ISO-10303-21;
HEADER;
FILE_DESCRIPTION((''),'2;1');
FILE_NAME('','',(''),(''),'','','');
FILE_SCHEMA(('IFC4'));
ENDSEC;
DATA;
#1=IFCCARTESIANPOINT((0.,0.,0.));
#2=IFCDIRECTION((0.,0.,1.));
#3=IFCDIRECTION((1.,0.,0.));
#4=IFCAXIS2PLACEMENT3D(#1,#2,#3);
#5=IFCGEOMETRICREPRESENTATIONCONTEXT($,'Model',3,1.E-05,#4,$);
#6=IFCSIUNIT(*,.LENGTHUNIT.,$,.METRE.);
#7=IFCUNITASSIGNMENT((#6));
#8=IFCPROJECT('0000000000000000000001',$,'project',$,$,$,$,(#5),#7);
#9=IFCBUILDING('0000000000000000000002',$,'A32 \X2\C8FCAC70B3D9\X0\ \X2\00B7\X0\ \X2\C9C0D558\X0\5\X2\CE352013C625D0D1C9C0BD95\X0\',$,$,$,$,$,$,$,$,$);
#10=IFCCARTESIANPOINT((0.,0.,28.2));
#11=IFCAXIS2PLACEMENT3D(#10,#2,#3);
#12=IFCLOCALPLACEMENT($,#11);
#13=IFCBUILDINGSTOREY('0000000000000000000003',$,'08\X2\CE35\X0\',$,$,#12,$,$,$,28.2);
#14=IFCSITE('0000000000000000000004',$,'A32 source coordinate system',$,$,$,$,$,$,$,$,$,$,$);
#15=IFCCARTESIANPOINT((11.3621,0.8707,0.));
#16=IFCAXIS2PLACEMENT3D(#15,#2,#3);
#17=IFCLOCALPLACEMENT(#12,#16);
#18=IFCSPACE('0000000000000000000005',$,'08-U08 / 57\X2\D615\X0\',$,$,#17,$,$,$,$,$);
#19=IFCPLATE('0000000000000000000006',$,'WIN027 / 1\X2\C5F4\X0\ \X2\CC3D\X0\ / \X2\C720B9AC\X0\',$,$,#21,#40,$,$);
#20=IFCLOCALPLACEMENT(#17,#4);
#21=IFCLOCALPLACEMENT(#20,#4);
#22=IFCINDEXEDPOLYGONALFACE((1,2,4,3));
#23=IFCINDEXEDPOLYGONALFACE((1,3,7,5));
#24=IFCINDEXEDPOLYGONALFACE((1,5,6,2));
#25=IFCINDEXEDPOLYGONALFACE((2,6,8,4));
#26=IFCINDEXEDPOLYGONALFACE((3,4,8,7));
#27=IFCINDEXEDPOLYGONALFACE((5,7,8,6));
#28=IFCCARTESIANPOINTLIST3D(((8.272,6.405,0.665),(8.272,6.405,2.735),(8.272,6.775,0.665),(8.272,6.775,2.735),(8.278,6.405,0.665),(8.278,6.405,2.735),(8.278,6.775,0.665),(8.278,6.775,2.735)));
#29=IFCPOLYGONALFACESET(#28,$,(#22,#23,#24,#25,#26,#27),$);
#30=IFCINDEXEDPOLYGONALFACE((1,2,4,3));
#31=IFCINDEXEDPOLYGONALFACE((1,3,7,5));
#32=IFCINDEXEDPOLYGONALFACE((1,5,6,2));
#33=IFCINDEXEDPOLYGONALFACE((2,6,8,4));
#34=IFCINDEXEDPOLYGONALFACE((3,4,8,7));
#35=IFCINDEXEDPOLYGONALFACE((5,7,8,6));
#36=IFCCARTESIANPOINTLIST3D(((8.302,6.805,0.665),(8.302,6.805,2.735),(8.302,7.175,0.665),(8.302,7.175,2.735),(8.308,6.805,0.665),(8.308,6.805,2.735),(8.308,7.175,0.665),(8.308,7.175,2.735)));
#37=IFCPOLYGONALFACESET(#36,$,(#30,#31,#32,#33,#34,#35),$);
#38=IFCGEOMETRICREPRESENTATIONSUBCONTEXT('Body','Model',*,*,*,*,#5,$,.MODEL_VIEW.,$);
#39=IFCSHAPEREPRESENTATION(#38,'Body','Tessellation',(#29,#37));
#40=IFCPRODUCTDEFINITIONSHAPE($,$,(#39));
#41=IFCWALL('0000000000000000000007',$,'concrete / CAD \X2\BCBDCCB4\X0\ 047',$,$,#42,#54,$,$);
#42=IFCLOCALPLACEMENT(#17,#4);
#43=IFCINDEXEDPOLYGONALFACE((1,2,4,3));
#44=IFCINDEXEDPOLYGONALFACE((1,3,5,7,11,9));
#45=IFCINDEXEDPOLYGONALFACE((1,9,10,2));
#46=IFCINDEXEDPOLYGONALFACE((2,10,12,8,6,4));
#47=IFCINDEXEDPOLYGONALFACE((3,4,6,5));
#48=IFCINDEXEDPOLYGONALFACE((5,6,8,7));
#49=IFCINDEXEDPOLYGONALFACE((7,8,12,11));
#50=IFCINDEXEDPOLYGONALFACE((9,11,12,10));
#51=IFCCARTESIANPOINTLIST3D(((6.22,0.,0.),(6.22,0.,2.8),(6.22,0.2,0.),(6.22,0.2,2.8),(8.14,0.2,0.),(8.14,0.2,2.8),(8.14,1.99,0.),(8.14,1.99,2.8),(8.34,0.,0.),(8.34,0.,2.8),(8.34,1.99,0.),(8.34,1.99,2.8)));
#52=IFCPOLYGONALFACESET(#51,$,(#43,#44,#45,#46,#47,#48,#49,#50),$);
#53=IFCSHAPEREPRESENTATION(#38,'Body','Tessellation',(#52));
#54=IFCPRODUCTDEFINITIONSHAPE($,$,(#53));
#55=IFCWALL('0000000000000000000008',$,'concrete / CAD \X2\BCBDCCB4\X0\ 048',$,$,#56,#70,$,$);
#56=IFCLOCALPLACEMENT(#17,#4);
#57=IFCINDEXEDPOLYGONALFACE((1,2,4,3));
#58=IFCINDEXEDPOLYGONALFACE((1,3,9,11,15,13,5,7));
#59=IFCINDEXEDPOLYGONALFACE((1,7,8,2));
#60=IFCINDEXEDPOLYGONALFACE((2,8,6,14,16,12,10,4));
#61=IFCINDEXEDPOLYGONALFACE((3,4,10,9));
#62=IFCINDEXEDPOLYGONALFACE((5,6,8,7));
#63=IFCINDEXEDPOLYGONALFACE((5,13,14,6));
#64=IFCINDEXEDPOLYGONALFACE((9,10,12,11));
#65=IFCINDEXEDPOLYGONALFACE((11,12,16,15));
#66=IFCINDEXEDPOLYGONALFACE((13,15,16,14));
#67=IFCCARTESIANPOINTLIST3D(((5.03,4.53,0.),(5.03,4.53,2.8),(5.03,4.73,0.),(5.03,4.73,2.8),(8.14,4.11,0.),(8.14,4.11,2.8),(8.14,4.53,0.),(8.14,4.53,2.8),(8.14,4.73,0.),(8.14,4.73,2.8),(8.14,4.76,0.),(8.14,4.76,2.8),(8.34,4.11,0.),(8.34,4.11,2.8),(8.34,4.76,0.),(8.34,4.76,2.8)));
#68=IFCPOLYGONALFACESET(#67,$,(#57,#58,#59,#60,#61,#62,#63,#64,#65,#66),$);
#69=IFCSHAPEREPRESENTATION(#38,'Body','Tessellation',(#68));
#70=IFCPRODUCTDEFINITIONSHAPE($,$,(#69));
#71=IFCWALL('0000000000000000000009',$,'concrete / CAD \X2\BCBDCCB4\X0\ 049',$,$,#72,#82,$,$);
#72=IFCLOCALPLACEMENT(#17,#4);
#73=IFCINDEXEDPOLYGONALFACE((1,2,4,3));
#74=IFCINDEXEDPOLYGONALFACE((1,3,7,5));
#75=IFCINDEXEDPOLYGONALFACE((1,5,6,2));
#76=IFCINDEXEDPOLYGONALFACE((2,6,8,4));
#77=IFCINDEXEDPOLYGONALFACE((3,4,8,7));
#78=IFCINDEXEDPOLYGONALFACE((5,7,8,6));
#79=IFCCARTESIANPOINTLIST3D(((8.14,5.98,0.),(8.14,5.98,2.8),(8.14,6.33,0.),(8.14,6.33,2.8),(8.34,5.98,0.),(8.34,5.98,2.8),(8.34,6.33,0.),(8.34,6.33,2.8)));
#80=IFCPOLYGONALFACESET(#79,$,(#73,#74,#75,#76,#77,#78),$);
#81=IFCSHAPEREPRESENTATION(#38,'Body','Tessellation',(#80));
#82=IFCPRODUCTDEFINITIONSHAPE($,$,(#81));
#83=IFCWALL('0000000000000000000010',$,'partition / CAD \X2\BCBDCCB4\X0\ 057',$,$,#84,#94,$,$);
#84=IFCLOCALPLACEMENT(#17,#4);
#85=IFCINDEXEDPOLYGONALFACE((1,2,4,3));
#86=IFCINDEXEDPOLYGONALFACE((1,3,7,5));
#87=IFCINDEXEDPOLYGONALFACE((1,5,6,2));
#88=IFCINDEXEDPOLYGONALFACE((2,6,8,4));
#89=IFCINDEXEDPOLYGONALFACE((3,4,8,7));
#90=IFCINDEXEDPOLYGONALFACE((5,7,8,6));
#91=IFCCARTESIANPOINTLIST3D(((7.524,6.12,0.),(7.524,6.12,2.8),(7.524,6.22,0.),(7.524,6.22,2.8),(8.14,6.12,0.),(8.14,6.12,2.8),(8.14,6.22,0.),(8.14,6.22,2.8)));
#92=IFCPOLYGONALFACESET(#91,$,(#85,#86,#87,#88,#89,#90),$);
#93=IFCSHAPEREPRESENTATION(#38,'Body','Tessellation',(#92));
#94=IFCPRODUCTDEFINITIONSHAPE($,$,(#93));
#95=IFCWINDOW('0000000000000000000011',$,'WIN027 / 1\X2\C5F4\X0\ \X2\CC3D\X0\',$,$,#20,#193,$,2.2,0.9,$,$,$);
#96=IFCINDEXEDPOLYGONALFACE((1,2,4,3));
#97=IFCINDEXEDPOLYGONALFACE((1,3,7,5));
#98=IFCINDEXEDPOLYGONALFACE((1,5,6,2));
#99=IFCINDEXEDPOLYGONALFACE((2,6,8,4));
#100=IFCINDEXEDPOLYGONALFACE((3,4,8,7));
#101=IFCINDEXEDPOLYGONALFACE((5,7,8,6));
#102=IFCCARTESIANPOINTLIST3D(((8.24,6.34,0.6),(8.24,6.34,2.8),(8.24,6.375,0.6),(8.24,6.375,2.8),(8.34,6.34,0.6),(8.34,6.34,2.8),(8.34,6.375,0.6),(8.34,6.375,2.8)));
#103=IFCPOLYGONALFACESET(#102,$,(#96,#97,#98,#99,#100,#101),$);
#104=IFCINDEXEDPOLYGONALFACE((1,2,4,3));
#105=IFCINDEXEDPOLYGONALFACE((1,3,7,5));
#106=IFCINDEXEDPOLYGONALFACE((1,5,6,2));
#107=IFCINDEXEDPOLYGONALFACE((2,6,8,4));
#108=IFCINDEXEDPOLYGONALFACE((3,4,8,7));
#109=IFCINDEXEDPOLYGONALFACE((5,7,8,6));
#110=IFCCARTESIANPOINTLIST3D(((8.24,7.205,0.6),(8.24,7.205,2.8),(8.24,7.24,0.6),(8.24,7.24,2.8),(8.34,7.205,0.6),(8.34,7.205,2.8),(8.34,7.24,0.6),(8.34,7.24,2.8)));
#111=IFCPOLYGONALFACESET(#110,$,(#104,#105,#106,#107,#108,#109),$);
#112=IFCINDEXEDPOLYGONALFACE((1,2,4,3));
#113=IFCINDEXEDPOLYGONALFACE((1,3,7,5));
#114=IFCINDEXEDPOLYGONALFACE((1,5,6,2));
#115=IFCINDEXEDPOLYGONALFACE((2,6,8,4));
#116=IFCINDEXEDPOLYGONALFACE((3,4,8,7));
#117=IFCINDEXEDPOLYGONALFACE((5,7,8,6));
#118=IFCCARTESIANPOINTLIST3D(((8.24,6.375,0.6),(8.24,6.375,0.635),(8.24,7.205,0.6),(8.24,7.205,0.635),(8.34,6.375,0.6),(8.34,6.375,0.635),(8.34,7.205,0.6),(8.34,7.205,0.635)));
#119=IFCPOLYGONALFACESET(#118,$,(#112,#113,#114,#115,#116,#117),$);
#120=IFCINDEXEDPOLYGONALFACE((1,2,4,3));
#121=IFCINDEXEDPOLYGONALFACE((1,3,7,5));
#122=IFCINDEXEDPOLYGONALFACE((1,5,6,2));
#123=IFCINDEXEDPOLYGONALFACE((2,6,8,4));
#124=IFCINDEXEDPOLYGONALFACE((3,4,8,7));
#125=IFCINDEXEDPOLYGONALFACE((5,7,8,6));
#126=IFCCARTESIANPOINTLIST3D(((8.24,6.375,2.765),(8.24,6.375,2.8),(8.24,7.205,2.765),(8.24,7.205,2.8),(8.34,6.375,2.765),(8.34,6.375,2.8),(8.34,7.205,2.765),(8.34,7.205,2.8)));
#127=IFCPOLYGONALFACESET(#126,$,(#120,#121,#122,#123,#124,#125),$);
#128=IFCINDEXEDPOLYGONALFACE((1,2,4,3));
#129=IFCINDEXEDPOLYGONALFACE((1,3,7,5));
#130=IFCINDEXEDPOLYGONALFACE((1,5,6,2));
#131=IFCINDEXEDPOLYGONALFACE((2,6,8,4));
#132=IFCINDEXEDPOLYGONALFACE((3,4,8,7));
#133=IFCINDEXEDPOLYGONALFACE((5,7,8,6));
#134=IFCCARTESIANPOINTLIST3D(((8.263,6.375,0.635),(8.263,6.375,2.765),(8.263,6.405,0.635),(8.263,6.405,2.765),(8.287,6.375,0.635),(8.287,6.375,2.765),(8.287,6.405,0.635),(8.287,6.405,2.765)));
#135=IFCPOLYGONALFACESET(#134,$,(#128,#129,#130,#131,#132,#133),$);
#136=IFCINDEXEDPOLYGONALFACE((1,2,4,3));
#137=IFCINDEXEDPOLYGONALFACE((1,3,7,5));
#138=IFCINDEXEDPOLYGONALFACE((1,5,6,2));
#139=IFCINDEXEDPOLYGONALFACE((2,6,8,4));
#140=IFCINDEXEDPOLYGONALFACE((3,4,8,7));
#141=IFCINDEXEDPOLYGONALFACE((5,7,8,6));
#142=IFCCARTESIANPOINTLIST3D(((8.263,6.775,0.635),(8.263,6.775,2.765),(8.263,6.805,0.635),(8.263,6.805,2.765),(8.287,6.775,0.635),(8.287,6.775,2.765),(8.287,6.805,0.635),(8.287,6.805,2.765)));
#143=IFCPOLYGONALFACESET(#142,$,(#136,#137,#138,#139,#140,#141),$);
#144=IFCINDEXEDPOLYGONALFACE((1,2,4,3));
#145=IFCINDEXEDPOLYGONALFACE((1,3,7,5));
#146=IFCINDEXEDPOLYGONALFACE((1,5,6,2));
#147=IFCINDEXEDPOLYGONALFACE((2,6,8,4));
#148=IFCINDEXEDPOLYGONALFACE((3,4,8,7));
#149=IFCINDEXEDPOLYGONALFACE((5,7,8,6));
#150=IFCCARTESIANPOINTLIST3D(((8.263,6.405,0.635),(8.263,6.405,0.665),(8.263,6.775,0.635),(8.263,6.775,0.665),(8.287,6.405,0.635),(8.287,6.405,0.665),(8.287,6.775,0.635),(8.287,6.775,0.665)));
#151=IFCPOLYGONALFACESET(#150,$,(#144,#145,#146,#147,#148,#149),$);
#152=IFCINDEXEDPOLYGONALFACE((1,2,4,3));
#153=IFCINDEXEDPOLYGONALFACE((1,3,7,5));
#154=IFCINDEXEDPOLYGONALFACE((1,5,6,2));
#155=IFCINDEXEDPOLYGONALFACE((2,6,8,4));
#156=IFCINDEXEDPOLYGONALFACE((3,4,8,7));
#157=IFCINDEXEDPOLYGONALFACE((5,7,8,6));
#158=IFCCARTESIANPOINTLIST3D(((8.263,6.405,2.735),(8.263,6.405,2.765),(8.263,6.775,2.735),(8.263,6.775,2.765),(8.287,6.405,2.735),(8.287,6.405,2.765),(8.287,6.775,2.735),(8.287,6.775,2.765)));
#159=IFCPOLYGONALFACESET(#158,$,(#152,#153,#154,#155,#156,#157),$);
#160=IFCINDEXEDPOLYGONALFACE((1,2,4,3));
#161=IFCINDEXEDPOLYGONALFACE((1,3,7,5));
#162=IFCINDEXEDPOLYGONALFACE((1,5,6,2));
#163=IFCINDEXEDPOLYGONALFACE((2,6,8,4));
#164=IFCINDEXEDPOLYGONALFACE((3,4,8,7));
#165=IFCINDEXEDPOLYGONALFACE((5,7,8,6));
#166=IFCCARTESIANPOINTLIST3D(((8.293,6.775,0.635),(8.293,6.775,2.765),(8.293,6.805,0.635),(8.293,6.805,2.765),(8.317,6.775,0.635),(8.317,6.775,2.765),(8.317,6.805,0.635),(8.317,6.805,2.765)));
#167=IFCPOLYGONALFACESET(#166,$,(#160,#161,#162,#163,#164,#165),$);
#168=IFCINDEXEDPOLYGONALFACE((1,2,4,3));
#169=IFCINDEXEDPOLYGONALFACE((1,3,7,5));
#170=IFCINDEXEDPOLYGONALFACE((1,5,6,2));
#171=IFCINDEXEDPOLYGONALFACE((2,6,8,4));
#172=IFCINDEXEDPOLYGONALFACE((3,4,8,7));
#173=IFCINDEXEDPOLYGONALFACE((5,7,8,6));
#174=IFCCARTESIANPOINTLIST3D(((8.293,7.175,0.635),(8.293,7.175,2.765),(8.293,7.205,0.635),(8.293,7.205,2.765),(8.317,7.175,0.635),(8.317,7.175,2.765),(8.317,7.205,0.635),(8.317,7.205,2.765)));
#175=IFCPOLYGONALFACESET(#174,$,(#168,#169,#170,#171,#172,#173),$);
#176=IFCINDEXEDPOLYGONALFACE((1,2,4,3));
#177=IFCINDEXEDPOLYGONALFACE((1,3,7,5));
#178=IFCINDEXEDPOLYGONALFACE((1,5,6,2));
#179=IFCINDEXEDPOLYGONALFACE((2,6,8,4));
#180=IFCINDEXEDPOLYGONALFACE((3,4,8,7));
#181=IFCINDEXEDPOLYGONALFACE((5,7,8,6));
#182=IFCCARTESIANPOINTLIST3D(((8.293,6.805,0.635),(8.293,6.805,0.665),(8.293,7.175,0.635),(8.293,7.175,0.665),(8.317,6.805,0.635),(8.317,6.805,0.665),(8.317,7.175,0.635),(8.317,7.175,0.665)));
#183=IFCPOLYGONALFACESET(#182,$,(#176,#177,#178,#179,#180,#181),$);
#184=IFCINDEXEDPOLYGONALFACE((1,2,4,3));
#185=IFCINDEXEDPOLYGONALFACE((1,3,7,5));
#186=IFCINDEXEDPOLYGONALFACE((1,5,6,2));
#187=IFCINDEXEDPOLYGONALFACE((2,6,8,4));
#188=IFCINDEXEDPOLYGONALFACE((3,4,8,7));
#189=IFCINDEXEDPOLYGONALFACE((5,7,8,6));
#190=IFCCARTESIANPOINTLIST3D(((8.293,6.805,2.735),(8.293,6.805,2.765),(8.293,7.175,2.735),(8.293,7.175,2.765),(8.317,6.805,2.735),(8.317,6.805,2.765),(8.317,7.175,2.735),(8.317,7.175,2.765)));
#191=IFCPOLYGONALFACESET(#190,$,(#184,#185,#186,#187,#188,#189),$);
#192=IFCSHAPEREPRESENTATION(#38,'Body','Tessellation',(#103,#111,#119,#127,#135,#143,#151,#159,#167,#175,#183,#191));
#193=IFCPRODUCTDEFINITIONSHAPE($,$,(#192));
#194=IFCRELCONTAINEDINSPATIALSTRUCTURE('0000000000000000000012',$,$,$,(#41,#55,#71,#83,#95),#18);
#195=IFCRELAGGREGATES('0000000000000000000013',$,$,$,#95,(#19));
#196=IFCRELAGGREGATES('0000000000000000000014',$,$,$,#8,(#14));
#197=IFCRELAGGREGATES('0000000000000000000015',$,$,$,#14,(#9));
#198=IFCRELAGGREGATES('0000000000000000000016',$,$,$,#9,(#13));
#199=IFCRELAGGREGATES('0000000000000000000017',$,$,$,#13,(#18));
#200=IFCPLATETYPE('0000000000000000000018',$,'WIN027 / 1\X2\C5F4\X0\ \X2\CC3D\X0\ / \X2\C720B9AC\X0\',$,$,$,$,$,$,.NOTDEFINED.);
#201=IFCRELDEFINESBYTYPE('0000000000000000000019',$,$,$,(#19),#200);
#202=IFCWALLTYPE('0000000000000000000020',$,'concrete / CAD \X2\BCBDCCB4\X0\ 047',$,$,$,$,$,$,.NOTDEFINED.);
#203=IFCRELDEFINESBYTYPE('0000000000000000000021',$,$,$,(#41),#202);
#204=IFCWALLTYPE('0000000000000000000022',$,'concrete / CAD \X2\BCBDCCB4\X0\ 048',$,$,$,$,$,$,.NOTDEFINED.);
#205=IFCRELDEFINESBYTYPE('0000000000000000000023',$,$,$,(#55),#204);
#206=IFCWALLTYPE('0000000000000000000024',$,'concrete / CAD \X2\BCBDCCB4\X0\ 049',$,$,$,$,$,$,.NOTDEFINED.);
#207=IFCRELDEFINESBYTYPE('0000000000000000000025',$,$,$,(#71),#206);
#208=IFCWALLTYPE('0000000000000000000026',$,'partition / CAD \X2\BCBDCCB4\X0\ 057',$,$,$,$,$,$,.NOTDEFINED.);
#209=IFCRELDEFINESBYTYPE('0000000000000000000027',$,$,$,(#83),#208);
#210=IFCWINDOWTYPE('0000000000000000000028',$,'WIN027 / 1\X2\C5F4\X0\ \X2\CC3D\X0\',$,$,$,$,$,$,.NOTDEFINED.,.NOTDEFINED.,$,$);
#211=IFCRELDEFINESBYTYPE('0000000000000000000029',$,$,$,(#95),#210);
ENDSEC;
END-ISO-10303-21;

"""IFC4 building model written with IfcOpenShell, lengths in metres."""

from ifc_helpers import new_model, si_unit, frame, origin, origin_with_axes, place, context, subcontext, project, spatial, polyline, outline, extrude, source, transform, mapped, type_object, type_shapes, element, aggregate, save


model = new_model("IFC4")

# Units and contexts
model_context = context("Model", 3, precision=1e-05, world=origin_with_axes())
body_context = subcontext(model_context, "Body", "Model", "MODEL_VIEW")
ifc_project = project(units=[si_unit("LENGTHUNIT", "METRE")], contexts=[model_context])

# Plate
storey_placement = place(None, frame((0.0, 0.0, 28.2), z_axis=(0.0, 0.0, 1.0), x_axis=(1.0, 0.0, 0.0)))
space_placement = place(storey_placement, frame((11.3621, 0.8707, 0.0), z_axis=(0.0, 0.0, 1.0), x_axis=(1.0, 0.0, 0.0)))
plate_type_1 = type_object("IfcPlateType", Name="WIN027 / 1열 창 / 유리", PredefinedType="NOTDEFINED")
shared_shape_1 = source(origin(), body_context, "Body", "SweptSolid", [
    extrude(outline(polyline([(8.272, 6.405), (8.272, 6.775), (8.278, 6.775), (8.278, 6.405), (8.272, 6.405)])), frame((0.0, 0.0, 0.665)), (0.0, 0.0, 1.0), 2.07),
    extrude(outline(polyline([(8.302, 6.805), (8.302, 7.175), (8.308, 7.175), (8.308, 6.805), (8.302, 6.805)])), frame((0.0, 0.0, 0.665)), (0.0, 0.0, 1.0), 2.07),
])
type_shapes(plate_type_1, [shared_shape_1])
window_1_placement = place(space_placement, origin_with_axes())
plate_1_placement = place(window_1_placement, origin_with_axes())
plate_1 = element("IfcPlate", 1, at=plate_1_placement, type_object=plate_type_1, Name="WIN027 / 1열 창 / 유리", context=body_context, shape_type="MappedRepresentation", body=[
    mapped(shared_shape_1, transform((0.0, 0.0, 0.0), scale=1.0)),
])

# Site, building, storey, space
site = spatial("IfcSite", under=ifc_project, Name="A32 source coordinate system")
building = spatial("IfcBuilding", under=site, Name="A32 주거동 · 지하5층–옥탑지붕")
storey = spatial("IfcBuildingStorey", under=building, at=storey_placement, Name="08층", Elevation=28.2)
space = spatial("IfcSpace", under=storey, at=space_placement, Name="08-U08 / 57형")

# Walls
wall_type_1 = type_object("IfcWallType", Name="concrete / CAD 벽체 047", PredefinedType="NOTDEFINED")
shared_shape_2 = source(origin(), body_context, "Body", "SweptSolid", [
    extrude(outline(polyline([(8.14, 1.99), (8.34, 1.99), (8.34, 0.0), (6.22, 0.0), (6.22, 0.2), (8.14, 0.2), (8.14, 1.99)])), origin(), (0.0, 0.0, 1.0), 2.8),
])
type_shapes(wall_type_1, [shared_shape_2])
wall_1_placement = place(space_placement, origin_with_axes())
element("IfcWall", 2, at=wall_1_placement, inside=space, type_object=wall_type_1, Name="concrete / CAD 벽체 047", context=body_context, shape_type="MappedRepresentation", body=[
    mapped(shared_shape_2, transform((0.0, 0.0, 0.0), scale=1.0)),
])
wall_type_2 = type_object("IfcWallType", Name="concrete / CAD 벽체 048", PredefinedType="NOTDEFINED")
shared_shape_3 = source(origin(), body_context, "Body", "SweptSolid", [
    extrude(outline(polyline([(8.14, 4.53), (5.03, 4.53), (5.03, 4.73), (8.14, 4.73), (8.14, 4.76), (8.34, 4.76), (8.34, 4.11), (8.14, 4.11), (8.14, 4.53)])), origin(), (0.0, 0.0, 1.0), 2.8),
])
type_shapes(wall_type_2, [shared_shape_3])
wall_2_placement = place(space_placement, origin_with_axes())
element("IfcWall", 3, at=wall_2_placement, inside=space, type_object=wall_type_2, Name="concrete / CAD 벽체 048", context=body_context, shape_type="MappedRepresentation", body=[
    mapped(shared_shape_3, transform((0.0, 0.0, 0.0), scale=1.0)),
])
wall_type_3 = type_object("IfcWallType", Name="concrete / CAD 벽체 049", PredefinedType="NOTDEFINED")
shared_shape_4 = source(origin(), body_context, "Body", "SweptSolid", [
    extrude(outline(polyline([(8.34, 6.33), (8.34, 5.98), (8.14, 5.98), (8.14, 6.33), (8.34, 6.33)])), origin(), (0.0, 0.0, 1.0), 2.8),
])
type_shapes(wall_type_3, [shared_shape_4])
wall_3_placement = place(space_placement, origin_with_axes())
element("IfcWall", 4, at=wall_3_placement, inside=space, type_object=wall_type_3, Name="concrete / CAD 벽체 049", context=body_context, shape_type="MappedRepresentation", body=[
    mapped(shared_shape_4, transform((0.0, 0.0, 0.0), scale=1.0)),
])
wall_type_4 = type_object("IfcWallType", Name="partition / CAD 벽체 057", PredefinedType="NOTDEFINED")
shared_shape_5 = source(origin(), body_context, "Body", "SweptSolid", [
    extrude(outline(polyline([(7.524, 6.22), (8.14, 6.22), (8.14, 6.12), (7.524, 6.12), (7.524, 6.22)])), origin(), (0.0, 0.0, 1.0), 2.8),
])
type_shapes(wall_type_4, [shared_shape_5])
wall_4_placement = place(space_placement, origin_with_axes())
element("IfcWall", 5, at=wall_4_placement, inside=space, type_object=wall_type_4, Name="partition / CAD 벽체 057", context=body_context, shape_type="MappedRepresentation", body=[
    mapped(shared_shape_5, transform((0.0, 0.0, 0.0), scale=1.0)),
])

# Window
window_type_1 = type_object("IfcWindowType", Name="WIN027 / 1열 창", PartitioningType="NOTDEFINED", PredefinedType="NOTDEFINED")
shared_shape_6 = source(origin(), body_context, "Body", "SweptSolid", [
    extrude(outline(polyline([(8.24, 6.34), (8.24, 6.375), (8.34, 6.375), (8.34, 6.34), (8.24, 6.34)])), frame((0.0, 0.0, 0.6)), (0.0, 0.0, 1.0), 2.2),
    extrude(outline(polyline([(8.24, 7.205), (8.24, 7.24), (8.34, 7.24), (8.34, 7.205), (8.24, 7.205)])), frame((0.0, 0.0, 0.6)), (0.0, 0.0, 1.0), 2.2),
    extrude(outline(polyline([(8.24, 6.375), (8.24, 7.205), (8.34, 7.205), (8.34, 6.375), (8.24, 6.375)])), frame((0.0, 0.0, 0.6)), (0.0, 0.0, 1.0), 0.035),
    extrude(outline(polyline([(8.24, 6.375), (8.24, 7.205), (8.34, 7.205), (8.34, 6.375), (8.24, 6.375)])), frame((0.0, 0.0, 2.765)), (0.0, 0.0, 1.0), 0.035),
    extrude(outline(polyline([(8.263, 6.375), (8.263, 6.405), (8.287, 6.405), (8.287, 6.375), (8.263, 6.375)])), frame((0.0, 0.0, 0.635)), (0.0, 0.0, 1.0), 2.13),
    extrude(outline(polyline([(8.263, 6.775), (8.263, 6.805), (8.287, 6.805), (8.287, 6.775), (8.263, 6.775)])), frame((0.0, 0.0, 0.635)), (0.0, 0.0, 1.0), 2.13),
    extrude(outline(polyline([(8.263, 6.405), (8.263, 6.775), (8.287, 6.775), (8.287, 6.405), (8.263, 6.405)])), frame((0.0, 0.0, 0.635)), (0.0, 0.0, 1.0), 0.03),
    extrude(outline(polyline([(8.263, 6.405), (8.263, 6.775), (8.287, 6.775), (8.287, 6.405), (8.263, 6.405)])), frame((0.0, 0.0, 2.735)), (0.0, 0.0, 1.0), 0.03),
    extrude(outline(polyline([(8.293, 6.775), (8.293, 6.805), (8.317, 6.805), (8.317, 6.775), (8.293, 6.775)])), frame((0.0, 0.0, 0.635)), (0.0, 0.0, 1.0), 2.13),
    extrude(outline(polyline([(8.293, 7.175), (8.293, 7.205), (8.317, 7.205), (8.317, 7.175), (8.293, 7.175)])), frame((0.0, 0.0, 0.635)), (0.0, 0.0, 1.0), 2.13),
    extrude(outline(polyline([(8.293, 6.805), (8.293, 7.175), (8.317, 7.175), (8.317, 6.805), (8.293, 6.805)])), frame((0.0, 0.0, 0.635)), (0.0, 0.0, 1.0), 0.03),
    extrude(outline(polyline([(8.293, 6.805), (8.293, 7.175), (8.317, 7.175), (8.317, 6.805), (8.293, 6.805)])), frame((0.0, 0.0, 2.735)), (0.0, 0.0, 1.0), 0.03),
])
type_shapes(window_type_1, [shared_shape_6])
window_1 = element("IfcWindow", 6, at=window_1_placement, inside=space, type_object=window_type_1, Name="WIN027 / 1열 창", OverallHeight=2.2, OverallWidth=0.9, context=body_context, shape_type="MappedRepresentation", body=[
    mapped(shared_shape_6, transform((0.0, 0.0, 0.0), scale=1.0)),
])
aggregate(window_1, [plate_1])

save(model, "model.ifc")
